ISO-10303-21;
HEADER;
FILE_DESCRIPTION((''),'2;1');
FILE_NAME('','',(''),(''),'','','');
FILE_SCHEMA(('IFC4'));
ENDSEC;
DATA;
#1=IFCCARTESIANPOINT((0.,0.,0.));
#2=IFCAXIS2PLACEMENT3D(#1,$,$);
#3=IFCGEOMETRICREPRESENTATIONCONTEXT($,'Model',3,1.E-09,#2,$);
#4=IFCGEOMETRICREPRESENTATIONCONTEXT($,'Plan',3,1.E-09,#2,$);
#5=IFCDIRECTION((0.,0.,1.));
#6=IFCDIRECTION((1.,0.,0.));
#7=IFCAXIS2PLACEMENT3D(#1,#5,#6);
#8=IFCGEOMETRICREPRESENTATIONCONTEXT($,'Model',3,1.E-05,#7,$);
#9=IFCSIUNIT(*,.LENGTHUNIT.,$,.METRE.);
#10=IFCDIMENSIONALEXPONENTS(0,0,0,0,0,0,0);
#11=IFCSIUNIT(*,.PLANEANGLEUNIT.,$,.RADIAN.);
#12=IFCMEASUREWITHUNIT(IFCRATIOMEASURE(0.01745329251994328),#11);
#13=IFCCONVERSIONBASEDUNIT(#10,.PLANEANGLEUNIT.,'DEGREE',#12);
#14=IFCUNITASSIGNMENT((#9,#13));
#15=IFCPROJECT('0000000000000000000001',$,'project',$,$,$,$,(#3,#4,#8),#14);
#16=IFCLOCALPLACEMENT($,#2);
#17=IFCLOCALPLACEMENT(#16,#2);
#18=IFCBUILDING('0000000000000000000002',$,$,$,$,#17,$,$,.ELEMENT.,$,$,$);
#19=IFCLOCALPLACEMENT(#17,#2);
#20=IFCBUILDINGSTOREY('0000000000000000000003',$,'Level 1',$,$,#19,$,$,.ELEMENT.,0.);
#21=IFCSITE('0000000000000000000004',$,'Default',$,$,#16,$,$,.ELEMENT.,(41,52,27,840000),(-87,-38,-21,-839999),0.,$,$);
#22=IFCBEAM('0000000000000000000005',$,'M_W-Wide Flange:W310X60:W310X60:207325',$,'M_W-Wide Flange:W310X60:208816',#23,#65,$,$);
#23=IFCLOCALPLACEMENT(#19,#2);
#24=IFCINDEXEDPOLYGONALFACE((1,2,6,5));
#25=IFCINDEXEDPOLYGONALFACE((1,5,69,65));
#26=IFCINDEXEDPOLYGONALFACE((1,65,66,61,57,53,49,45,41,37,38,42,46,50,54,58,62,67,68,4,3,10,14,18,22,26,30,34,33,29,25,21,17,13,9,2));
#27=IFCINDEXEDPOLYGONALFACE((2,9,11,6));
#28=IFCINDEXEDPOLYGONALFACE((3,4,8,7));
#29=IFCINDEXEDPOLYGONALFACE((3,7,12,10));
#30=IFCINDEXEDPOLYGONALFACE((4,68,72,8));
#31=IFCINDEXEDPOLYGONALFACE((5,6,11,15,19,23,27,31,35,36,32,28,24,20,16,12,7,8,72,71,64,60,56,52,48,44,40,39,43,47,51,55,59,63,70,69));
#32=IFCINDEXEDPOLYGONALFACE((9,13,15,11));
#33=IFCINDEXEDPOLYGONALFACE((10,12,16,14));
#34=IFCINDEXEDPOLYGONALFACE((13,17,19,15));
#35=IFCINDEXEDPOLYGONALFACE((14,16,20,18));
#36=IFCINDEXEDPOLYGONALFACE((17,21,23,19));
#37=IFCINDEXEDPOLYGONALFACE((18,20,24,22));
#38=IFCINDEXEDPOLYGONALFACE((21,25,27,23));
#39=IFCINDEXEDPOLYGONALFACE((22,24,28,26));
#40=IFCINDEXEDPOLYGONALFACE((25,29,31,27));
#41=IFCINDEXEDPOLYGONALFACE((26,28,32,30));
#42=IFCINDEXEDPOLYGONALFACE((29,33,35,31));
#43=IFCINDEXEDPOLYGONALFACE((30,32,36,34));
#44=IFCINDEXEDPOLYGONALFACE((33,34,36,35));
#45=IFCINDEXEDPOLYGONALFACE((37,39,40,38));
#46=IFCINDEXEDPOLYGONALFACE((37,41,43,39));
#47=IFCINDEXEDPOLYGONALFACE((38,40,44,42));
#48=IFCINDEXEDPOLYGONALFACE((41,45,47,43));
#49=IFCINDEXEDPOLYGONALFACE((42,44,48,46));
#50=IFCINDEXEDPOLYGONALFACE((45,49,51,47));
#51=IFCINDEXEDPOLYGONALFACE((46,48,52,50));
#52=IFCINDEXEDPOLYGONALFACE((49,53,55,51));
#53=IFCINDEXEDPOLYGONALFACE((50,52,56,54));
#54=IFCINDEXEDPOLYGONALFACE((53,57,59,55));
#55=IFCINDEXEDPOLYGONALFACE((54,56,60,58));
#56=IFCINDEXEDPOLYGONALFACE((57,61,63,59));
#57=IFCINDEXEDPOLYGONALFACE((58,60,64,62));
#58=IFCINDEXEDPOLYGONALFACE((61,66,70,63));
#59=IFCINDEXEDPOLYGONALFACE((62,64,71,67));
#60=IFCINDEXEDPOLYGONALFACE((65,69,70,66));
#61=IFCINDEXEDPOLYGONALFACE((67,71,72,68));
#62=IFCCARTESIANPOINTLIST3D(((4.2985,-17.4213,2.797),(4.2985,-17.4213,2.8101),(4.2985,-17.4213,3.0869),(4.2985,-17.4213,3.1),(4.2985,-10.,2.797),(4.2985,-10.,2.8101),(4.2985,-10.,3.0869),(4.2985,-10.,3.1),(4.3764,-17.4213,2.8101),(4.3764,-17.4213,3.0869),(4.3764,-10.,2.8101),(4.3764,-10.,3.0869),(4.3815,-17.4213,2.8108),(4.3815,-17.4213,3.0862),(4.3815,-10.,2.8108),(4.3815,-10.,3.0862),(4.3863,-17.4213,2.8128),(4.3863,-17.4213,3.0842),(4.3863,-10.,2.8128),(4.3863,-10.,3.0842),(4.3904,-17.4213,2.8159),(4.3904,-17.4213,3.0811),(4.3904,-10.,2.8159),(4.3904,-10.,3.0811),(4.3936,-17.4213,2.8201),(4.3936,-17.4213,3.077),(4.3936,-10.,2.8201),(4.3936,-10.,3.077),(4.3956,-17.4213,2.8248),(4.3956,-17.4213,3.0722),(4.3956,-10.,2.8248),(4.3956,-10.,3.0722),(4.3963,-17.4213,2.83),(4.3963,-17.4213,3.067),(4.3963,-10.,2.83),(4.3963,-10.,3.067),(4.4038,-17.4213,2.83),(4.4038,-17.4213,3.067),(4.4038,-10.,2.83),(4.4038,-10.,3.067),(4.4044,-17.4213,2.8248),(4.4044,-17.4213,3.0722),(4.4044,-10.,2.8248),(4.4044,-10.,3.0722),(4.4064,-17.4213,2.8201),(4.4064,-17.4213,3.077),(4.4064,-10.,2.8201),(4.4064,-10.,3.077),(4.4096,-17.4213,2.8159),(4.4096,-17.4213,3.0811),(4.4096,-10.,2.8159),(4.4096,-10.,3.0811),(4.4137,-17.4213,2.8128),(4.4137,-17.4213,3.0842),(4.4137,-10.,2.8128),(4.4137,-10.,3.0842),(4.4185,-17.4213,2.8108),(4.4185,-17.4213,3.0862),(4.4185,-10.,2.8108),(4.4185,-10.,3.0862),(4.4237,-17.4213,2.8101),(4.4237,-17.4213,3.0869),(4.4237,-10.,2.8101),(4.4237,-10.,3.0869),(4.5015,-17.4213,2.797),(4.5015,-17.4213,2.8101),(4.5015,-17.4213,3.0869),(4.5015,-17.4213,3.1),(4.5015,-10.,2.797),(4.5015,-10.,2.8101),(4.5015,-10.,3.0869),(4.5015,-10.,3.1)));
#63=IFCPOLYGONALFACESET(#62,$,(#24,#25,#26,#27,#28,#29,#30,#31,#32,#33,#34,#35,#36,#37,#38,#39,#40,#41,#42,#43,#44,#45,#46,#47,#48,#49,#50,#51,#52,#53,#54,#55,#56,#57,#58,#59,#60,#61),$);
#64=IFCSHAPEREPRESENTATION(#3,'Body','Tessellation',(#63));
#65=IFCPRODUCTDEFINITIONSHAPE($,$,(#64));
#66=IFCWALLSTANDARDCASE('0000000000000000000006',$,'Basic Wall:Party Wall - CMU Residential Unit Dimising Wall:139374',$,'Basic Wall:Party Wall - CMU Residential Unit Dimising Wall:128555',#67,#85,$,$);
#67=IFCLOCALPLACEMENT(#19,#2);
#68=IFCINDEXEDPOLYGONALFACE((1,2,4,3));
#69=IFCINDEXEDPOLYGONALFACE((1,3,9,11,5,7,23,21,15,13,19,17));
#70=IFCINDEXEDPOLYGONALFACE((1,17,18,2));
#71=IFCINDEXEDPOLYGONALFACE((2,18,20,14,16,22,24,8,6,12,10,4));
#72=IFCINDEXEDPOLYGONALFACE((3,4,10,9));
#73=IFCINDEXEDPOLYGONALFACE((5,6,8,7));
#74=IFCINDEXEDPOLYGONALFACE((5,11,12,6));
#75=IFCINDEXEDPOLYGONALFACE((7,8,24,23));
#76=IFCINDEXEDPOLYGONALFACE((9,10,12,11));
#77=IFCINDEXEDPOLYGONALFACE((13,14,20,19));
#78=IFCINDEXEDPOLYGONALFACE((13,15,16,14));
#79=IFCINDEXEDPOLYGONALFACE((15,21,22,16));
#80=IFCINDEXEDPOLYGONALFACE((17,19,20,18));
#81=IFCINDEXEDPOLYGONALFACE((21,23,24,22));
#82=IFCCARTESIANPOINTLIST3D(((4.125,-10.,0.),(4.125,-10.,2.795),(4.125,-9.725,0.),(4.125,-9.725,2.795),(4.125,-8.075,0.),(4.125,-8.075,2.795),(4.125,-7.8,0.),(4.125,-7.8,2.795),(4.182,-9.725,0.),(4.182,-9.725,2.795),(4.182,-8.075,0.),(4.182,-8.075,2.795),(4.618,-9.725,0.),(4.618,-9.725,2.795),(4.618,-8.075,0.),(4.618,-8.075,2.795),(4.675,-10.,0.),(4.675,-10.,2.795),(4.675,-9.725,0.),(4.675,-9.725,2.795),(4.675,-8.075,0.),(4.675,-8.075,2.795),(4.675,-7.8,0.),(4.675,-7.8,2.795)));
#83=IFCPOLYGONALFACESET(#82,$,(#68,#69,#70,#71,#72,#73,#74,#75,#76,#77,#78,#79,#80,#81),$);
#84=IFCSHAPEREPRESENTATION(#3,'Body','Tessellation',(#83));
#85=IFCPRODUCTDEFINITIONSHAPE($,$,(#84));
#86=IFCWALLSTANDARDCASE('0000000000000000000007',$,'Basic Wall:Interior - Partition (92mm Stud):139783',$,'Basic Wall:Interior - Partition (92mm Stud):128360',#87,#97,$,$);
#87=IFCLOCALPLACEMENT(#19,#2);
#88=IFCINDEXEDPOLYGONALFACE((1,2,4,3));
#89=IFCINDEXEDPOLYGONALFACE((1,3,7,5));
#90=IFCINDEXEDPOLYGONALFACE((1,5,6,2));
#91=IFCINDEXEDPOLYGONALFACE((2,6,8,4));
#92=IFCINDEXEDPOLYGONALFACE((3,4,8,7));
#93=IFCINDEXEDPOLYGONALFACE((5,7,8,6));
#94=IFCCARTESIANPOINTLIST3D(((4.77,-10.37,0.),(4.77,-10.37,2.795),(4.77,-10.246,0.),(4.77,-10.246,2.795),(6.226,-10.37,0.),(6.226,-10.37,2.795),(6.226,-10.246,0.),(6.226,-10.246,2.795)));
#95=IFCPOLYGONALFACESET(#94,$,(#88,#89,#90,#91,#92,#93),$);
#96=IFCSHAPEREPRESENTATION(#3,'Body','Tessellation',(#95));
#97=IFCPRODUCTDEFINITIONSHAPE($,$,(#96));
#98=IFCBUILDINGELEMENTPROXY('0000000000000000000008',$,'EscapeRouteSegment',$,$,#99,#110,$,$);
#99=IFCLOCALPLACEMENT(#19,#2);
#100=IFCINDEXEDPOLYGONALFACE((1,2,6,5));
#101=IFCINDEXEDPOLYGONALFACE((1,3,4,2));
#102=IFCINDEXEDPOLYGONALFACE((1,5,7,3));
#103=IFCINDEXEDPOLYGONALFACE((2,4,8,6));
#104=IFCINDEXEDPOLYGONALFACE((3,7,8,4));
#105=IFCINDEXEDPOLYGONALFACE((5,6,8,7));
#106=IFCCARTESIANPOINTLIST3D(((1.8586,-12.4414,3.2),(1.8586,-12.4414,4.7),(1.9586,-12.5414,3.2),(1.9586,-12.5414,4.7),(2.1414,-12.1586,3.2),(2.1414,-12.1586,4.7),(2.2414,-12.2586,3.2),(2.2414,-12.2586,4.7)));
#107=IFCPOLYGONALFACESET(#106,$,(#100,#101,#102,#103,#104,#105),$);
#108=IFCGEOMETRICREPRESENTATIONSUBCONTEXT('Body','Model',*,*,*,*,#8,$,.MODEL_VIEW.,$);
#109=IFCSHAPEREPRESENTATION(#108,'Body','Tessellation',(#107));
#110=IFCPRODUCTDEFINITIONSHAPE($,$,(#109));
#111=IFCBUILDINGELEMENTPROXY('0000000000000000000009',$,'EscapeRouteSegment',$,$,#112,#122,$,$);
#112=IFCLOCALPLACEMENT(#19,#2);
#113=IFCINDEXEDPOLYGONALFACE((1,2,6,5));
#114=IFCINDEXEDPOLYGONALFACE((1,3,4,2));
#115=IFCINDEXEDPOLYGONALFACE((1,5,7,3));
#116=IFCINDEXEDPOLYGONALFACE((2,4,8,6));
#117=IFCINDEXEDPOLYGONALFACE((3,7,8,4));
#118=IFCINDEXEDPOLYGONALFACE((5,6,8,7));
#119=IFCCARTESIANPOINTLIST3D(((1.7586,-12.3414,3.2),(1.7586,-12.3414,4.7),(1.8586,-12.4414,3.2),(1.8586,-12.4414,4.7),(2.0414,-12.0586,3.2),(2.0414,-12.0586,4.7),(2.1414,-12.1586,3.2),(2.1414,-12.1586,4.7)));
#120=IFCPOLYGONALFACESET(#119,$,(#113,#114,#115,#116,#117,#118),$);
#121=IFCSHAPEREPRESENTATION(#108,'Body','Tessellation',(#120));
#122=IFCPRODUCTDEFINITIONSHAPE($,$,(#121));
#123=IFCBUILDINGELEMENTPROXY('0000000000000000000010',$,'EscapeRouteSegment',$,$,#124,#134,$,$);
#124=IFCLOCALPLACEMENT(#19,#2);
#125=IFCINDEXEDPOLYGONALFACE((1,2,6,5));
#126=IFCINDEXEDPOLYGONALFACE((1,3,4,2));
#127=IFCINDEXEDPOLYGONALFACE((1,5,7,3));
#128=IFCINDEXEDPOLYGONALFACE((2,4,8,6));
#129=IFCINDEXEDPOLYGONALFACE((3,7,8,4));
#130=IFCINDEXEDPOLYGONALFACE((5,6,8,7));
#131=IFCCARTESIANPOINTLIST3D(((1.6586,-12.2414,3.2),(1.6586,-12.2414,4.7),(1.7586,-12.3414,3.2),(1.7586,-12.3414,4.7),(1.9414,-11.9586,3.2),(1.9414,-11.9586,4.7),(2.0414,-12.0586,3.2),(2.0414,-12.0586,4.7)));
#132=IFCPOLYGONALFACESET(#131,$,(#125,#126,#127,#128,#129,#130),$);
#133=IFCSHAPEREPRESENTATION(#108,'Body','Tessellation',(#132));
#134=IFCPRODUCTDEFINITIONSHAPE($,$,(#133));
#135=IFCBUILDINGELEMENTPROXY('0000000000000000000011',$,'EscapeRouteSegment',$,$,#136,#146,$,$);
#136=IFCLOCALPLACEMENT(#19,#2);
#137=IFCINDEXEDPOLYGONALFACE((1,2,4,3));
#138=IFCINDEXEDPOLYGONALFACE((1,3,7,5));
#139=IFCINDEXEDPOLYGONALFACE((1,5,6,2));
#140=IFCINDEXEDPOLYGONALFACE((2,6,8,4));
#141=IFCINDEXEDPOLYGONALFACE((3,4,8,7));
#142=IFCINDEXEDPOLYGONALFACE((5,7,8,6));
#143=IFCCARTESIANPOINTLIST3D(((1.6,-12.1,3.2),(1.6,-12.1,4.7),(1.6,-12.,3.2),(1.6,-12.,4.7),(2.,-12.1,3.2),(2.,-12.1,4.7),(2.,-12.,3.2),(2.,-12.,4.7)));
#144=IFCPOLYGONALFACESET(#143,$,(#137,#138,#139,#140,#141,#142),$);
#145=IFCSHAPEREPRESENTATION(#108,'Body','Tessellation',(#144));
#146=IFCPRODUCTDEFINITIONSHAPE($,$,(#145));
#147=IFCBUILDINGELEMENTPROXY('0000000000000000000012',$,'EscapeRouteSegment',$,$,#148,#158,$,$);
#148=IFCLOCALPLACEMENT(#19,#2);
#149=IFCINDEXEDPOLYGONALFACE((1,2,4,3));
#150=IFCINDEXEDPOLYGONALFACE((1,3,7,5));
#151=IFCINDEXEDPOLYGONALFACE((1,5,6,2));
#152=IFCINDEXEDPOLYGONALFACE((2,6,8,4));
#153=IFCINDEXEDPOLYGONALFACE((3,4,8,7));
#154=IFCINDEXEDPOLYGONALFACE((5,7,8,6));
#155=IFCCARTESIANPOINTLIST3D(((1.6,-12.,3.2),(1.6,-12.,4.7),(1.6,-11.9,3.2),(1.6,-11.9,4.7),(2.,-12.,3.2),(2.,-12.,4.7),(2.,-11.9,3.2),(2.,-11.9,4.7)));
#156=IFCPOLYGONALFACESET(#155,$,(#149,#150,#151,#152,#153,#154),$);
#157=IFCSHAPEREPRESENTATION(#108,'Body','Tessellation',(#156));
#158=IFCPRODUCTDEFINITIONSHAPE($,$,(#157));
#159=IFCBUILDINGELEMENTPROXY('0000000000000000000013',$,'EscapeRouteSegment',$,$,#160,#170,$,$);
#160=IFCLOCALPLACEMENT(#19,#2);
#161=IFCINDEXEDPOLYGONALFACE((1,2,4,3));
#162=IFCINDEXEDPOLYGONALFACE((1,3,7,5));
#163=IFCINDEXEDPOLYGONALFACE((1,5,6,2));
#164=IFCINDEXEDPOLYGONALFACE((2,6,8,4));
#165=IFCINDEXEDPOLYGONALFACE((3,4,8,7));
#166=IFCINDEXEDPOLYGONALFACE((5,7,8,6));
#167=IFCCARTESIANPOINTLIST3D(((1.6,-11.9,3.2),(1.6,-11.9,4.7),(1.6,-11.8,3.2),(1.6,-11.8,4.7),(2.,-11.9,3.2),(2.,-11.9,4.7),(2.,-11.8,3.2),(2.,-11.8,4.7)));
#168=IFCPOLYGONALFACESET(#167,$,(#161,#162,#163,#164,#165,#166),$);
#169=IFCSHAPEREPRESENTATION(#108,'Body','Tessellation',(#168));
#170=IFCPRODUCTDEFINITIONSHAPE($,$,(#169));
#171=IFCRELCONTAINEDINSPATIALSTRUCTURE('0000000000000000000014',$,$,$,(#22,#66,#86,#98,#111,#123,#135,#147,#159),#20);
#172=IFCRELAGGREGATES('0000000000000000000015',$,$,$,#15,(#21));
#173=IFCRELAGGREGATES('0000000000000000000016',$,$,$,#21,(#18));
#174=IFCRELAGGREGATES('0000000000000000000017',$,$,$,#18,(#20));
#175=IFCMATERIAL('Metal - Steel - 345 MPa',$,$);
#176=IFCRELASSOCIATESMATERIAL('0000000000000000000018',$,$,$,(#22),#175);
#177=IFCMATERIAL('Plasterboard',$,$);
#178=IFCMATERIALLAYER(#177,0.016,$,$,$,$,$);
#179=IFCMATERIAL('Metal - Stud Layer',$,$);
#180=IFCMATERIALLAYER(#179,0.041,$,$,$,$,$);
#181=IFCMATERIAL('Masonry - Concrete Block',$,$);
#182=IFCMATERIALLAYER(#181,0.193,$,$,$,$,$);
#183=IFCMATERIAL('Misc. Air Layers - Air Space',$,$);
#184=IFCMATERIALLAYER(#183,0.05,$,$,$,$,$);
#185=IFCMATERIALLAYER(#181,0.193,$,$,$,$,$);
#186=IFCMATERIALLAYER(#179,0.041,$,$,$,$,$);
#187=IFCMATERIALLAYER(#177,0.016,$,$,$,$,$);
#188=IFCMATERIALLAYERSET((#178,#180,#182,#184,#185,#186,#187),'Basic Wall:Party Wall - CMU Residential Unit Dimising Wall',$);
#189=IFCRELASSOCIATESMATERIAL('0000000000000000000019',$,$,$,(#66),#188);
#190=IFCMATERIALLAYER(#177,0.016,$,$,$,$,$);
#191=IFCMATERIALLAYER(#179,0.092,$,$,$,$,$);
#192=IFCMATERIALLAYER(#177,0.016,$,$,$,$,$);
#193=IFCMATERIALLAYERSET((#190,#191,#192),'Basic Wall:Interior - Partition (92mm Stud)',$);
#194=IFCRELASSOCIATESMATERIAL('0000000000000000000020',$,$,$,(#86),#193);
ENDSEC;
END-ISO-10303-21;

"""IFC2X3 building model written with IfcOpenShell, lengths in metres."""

from ifc_helpers import new_model, entity, si_unit, converted_unit, frame, frame_2d, origin, origin_with_axes, place, context, subcontext, project, spatial, polyline, circle_curve, parameter, trimmed, segment, composite_curve, rectangle, outline, extrude, clip, bounded_halfspace, material, layer, layer_set, layer_usage, element, save


model = new_model("IFC2X3")

# Units and contexts
model_context_1 = context("Model", 3, precision=1e-09, world=origin())
plan_context = context("Plan", 3, precision=1e-09, world=origin())
model_context_2 = context("Model", 3, precision=1e-05, world=origin_with_axes())
body_context = subcontext(model_context_2, "Body", "Model", "MODEL_VIEW")
ifc_project = project(units=[si_unit("LENGTHUNIT", "METRE"), converted_unit("PLANEANGLEUNIT", "DEGREE", entity("IfcRatioMeasure", 0.01745329251994328), si_unit("PLANEANGLEUNIT", "RADIAN"), dimensions=[0, 0, 0, 0, 0, 0, 0])], contexts=[model_context_1, plan_context, model_context_2])

# Site, building, storey
site_placement = place(None, origin())
site = spatial("IfcSite", under=ifc_project, at=site_placement, Name="Default", CompositionType="ELEMENT", RefLatitude=(41, 52, 27, 840000), RefLongitude=(-87, -38, -21, -839999), RefElevation=0.0)
building_placement = place(site_placement, origin())
building = spatial("IfcBuilding", under=site, at=building_placement, CompositionType="ELEMENT")
storey_placement = place(building_placement, origin())
storey = spatial("IfcBuildingStorey", under=building, at=storey_placement, Name="Level 1", CompositionType="ELEMENT", Elevation=0.0)

# Beam
ifc_material_1 = material(Name="Metal - Steel - 345 MPa")
beam_placement = place(storey_placement, frame((4.4, -10.0, 3.1), z_axis=(0.0, 0.0, 1.0), x_axis=(-1.0, 0.0, 0.0)))
element("IfcBeam", 1, at=beam_placement, inside=storey, material=ifc_material_1, Name="M_W-Wide Flange:W310X60:W310X60:207325", ObjectType="M_W-Wide Flange:W310X60:208816", context=model_context_1, shape_type="SweptSolid", body=[
    extrude(outline(composite_curve([segment(polyline([(0.1384, -0.1015), (0.1515, -0.1015)]), True, "CONTINUOUS"), segment(polyline([(0.1515, -0.1015), (0.1515, 0.1015)]), True, "CONTINUOUS"), segment(polyline([(0.1515, 0.1015), (0.1384, 0.1015)]), True, "CONTINUOUS"), segment(polyline([(0.1384, 0.1015), (0.1384, 0.0236)]), True, "CONTINUOUS"), segment(trimmed(circle_curve(frame_2d((0.1185, 0.0236), x_axis=(0.0, 1.0)), 0.0199), [parameter(180.0)], [parameter(270.0)], True, "PARAMETER"), False, "CONTINUOUS"), segment(polyline([(0.1185, 0.0037), (-0.1185, 0.0037)]), True, "CONTINUOUS"), segment(trimmed(circle_curve(frame_2d((-0.1185, 0.0236), x_axis=(0.0, 1.0)), 0.0199), [parameter(90.0)], [parameter(180.0)], True, "PARAMETER"), False, "CONTINUOUS"), segment(polyline([(-0.1384, 0.0236), (-0.1384, 0.1015)]), True, "CONTINUOUS"), segment(polyline([(-0.1384, 0.1015), (-0.1515, 0.1015)]), True, "CONTINUOUS"), segment(polyline([(-0.1515, 0.1015), (-0.1515, -0.1015)]), True, "CONTINUOUS"), segment(polyline([(-0.1515, -0.1015), (-0.1384, -0.1015)]), True, "CONTINUOUS"), segment(polyline([(-0.1384, -0.1015), (-0.1384, -0.0237)]), True, "CONTINUOUS"), segment(trimmed(circle_curve(frame_2d((-0.1185, -0.0237), x_axis=(0.0, 1.0)), 0.0199), [parameter(360.0)], [parameter(90.0)], True, "PARAMETER"), False, "CONTINUOUS"), segment(polyline([(-0.1185, -0.0038), (0.1185, -0.0038)]), True, "CONTINUOUS"), segment(trimmed(circle_curve(frame_2d((0.1185, -0.0237), x_axis=(0.0, 1.0)), 0.0199), [parameter(270.0)], [parameter(0.0)], True, "PARAMETER"), False, "CONTINUOUS"), segment(polyline([(0.1384, -0.0237), (0.1384, -0.1015)]), True, "CONTINUOUS")], self_intersect=False)), frame((0.0, 7.4213, -0.1515), z_axis=(0.0, -1.0, 0.0), x_axis=(0.0, 0.0, -1.0)), (0.0, 0.0, 1.0), 7.4213),
])

# Walls
ifc_material_2 = material(Name="Plasterboard")
ifc_layer_1 = layer(ifc_material_2, 0.016)
ifc_material_3 = material(Name="Metal - Stud Layer")
ifc_layer_2 = layer(ifc_material_3, 0.041)
ifc_material_4 = material(Name="Masonry - Concrete Block")
ifc_layer_3 = layer(ifc_material_4, 0.193)
ifc_material_5 = material(Name="Misc. Air Layers - Air Space")
ifc_layer_4 = layer(ifc_material_5, 0.05)
ifc_layer_5 = layer(ifc_material_4, 0.193)
ifc_layer_6 = layer(ifc_material_3, 0.041)
ifc_layer_7 = layer(ifc_material_2, 0.016)
ifc_layer_set_1 = layer_set([ifc_layer_1, ifc_layer_2, ifc_layer_3, ifc_layer_4, ifc_layer_5, ifc_layer_6, ifc_layer_7], Name="Basic Wall:Party Wall - CMU Residential Unit Dimising Wall")
ifc_layer_usage_1 = layer_usage(ifc_layer_set_1, "AXIS2", "NEGATIVE", 0.275)
wall_1_placement = place(storey_placement, frame((4.4, -10.0, 0.0), z_axis=(0.0, 0.0, 1.0), x_axis=(0.0, 1.0, 0.0)))
element("IfcWallStandardCase", 2, at=wall_1_placement, inside=storey, material=ifc_layer_usage_1, Name="Basic Wall:Party Wall - CMU Residential Unit Dimising Wall:139374", ObjectType="Basic Wall:Party Wall - CMU Residential Unit Dimising Wall:128555", context=model_context_1, shape_type="Clipping", body=[
    clip(clip(extrude(rectangle(XDim=2.2, YDim=0.55, at=frame_2d((1.1, 0.0), x_axis=(-1.0, 0.0))), origin(), (0.0, 0.0, 1.0), 2.795), bounded_halfspace(frame((1.925, 0.218, 0.0), z_axis=(0.0, -1.0, 0.0), x_axis=(1.0, 0.0, 0.0)), True, frame((1.925, 0.218, 0.0), z_axis=(0.0, -1.0, 0.0), x_axis=(1.0, 0.0, 0.0)), polyline([(0.0, 0.0), (0.0, 2.795), (-1.65, 2.795), (-1.65, 0.0), (0.0, 0.0)]))), bounded_halfspace(frame((0.275, -0.218, 0.0), z_axis=(0.0, 1.0, 0.0), x_axis=(-1.0, 0.0, 0.0)), True, frame((0.275, -0.218, 0.0), z_axis=(0.0, 1.0, 0.0), x_axis=(-1.0, 0.0, 0.0)), polyline([(0.0, 0.0), (0.0, 2.795), (-1.65, 2.795), (-1.65, 0.0), (0.0, 0.0)]))),
])
ifc_layer_8 = layer(ifc_material_2, 0.016)
ifc_layer_9 = layer(ifc_material_3, 0.092)
ifc_layer_10 = layer(ifc_material_2, 0.016)
ifc_layer_set_2 = layer_set([ifc_layer_8, ifc_layer_9, ifc_layer_10], Name="Basic Wall:Interior - Partition (92mm Stud)")
ifc_layer_usage_2 = layer_usage(ifc_layer_set_2, "AXIS2", "NEGATIVE", 0.062)
wall_2_placement = place(storey_placement, frame((4.77, -10.308, 0.0)))
element("IfcWallStandardCase", 3, at=wall_2_placement, inside=storey, material=ifc_layer_usage_2, Name="Basic Wall:Interior - Partition (92mm Stud):139783", ObjectType="Basic Wall:Interior - Partition (92mm Stud):128360", context=model_context_1, shape_type="SweptSolid", body=[
    extrude(rectangle(XDim=1.456, YDim=0.124, at=frame_2d((0.728, 0.0), x_axis=(-1.0, 0.0))), origin(), (0.0, 0.0, 1.0), 2.795),
])

# Building element proxies
proxy_1_placement = place(storey_placement, frame((2.1, -12.4, 3.2), z_axis=(0.0, 0.0, 1.0), x_axis=(-0.707108, 0.707105, 0.0)))
element("IfcBuildingElementProxy", 4, at=proxy_1_placement, inside=storey, Name="EscapeRouteSegment", context=body_context, shape_type="SweptSolid", body=[
    extrude(outline(polyline([(0.0, -0.2), (0.0, 0.2), (0.1414, 0.2), (0.1414, -0.2), (0.0, -0.2)])), origin_with_axes(), (0.0, 0.0, 1.0), 1.5),
])
proxy_2_placement = place(storey_placement, frame((2.0, -12.3, 3.2), z_axis=(0.0, 0.0, 1.0), x_axis=(-0.707105, 0.707108, 0.0)))
element("IfcBuildingElementProxy", 5, at=proxy_2_placement, inside=storey, Name="EscapeRouteSegment", context=body_context, shape_type="SweptSolid", body=[
    extrude(outline(polyline([(0.0, -0.2), (0.0, 0.2), (0.1414, 0.2), (0.1414, -0.2), (0.0, -0.2)])), origin_with_axes(), (0.0, 0.0, 1.0), 1.5),
])
proxy_3_placement = place(storey_placement, frame((1.9, -12.2, 3.2), z_axis=(0.0, 0.0, 1.0), x_axis=(-0.707109, 0.707105, 0.0)))
element("IfcBuildingElementProxy", 6, at=proxy_3_placement, inside=storey, Name="EscapeRouteSegment", context=body_context, shape_type="SweptSolid", body=[
    extrude(outline(polyline([(0.0, -0.2), (0.0, 0.2), (0.1414, 0.2), (0.1414, -0.2), (0.0, -0.2)])), origin_with_axes(), (0.0, 0.0, 1.0), 1.5),
])
for number, where, z_axis, x_axis, name in (
    (7, (1.8, -12.1, 3.2), (0.0, 0.0, 1.0), (0.0, 1.0, 0.0), "EscapeRouteSegment"),
    (8, (1.8, -12.0, 3.2), (0.0, 0.0, 1.0), (0.0, 1.0, 0.0), "EscapeRouteSegment"),
):
    element("IfcBuildingElementProxy", number, at=place(storey_placement, frame(where, z_axis=z_axis, x_axis=x_axis)), inside=storey, Name=name, context=body_context, shape_type="SweptSolid", body=[
        extrude(outline(polyline([(0.0, -0.2), (0.0, 0.2), (0.1, 0.2), (0.1, -0.2), (0.0, -0.2)])), origin_with_axes(), (0.0, 0.0, 1.0), 1.5),
    ])
proxy_4_placement = place(storey_placement, frame((1.8, -11.9, 3.2), z_axis=(0.0, 0.0, 1.0), x_axis=(0.0, 1.0, 0.0)))
element("IfcBuildingElementProxy", 9, at=proxy_4_placement, inside=storey, Name="EscapeRouteSegment", context=body_context, shape_type="SweptSolid", body=[
    extrude(outline(polyline([(0.0, -0.2), (0.0, 0.2), (0.1, 0.2), (0.1, -0.2), (0.0, -0.2)])), origin_with_axes(), (0.0, 0.0, 1.0), 1.5),
])

save(model, "model.ifc")
